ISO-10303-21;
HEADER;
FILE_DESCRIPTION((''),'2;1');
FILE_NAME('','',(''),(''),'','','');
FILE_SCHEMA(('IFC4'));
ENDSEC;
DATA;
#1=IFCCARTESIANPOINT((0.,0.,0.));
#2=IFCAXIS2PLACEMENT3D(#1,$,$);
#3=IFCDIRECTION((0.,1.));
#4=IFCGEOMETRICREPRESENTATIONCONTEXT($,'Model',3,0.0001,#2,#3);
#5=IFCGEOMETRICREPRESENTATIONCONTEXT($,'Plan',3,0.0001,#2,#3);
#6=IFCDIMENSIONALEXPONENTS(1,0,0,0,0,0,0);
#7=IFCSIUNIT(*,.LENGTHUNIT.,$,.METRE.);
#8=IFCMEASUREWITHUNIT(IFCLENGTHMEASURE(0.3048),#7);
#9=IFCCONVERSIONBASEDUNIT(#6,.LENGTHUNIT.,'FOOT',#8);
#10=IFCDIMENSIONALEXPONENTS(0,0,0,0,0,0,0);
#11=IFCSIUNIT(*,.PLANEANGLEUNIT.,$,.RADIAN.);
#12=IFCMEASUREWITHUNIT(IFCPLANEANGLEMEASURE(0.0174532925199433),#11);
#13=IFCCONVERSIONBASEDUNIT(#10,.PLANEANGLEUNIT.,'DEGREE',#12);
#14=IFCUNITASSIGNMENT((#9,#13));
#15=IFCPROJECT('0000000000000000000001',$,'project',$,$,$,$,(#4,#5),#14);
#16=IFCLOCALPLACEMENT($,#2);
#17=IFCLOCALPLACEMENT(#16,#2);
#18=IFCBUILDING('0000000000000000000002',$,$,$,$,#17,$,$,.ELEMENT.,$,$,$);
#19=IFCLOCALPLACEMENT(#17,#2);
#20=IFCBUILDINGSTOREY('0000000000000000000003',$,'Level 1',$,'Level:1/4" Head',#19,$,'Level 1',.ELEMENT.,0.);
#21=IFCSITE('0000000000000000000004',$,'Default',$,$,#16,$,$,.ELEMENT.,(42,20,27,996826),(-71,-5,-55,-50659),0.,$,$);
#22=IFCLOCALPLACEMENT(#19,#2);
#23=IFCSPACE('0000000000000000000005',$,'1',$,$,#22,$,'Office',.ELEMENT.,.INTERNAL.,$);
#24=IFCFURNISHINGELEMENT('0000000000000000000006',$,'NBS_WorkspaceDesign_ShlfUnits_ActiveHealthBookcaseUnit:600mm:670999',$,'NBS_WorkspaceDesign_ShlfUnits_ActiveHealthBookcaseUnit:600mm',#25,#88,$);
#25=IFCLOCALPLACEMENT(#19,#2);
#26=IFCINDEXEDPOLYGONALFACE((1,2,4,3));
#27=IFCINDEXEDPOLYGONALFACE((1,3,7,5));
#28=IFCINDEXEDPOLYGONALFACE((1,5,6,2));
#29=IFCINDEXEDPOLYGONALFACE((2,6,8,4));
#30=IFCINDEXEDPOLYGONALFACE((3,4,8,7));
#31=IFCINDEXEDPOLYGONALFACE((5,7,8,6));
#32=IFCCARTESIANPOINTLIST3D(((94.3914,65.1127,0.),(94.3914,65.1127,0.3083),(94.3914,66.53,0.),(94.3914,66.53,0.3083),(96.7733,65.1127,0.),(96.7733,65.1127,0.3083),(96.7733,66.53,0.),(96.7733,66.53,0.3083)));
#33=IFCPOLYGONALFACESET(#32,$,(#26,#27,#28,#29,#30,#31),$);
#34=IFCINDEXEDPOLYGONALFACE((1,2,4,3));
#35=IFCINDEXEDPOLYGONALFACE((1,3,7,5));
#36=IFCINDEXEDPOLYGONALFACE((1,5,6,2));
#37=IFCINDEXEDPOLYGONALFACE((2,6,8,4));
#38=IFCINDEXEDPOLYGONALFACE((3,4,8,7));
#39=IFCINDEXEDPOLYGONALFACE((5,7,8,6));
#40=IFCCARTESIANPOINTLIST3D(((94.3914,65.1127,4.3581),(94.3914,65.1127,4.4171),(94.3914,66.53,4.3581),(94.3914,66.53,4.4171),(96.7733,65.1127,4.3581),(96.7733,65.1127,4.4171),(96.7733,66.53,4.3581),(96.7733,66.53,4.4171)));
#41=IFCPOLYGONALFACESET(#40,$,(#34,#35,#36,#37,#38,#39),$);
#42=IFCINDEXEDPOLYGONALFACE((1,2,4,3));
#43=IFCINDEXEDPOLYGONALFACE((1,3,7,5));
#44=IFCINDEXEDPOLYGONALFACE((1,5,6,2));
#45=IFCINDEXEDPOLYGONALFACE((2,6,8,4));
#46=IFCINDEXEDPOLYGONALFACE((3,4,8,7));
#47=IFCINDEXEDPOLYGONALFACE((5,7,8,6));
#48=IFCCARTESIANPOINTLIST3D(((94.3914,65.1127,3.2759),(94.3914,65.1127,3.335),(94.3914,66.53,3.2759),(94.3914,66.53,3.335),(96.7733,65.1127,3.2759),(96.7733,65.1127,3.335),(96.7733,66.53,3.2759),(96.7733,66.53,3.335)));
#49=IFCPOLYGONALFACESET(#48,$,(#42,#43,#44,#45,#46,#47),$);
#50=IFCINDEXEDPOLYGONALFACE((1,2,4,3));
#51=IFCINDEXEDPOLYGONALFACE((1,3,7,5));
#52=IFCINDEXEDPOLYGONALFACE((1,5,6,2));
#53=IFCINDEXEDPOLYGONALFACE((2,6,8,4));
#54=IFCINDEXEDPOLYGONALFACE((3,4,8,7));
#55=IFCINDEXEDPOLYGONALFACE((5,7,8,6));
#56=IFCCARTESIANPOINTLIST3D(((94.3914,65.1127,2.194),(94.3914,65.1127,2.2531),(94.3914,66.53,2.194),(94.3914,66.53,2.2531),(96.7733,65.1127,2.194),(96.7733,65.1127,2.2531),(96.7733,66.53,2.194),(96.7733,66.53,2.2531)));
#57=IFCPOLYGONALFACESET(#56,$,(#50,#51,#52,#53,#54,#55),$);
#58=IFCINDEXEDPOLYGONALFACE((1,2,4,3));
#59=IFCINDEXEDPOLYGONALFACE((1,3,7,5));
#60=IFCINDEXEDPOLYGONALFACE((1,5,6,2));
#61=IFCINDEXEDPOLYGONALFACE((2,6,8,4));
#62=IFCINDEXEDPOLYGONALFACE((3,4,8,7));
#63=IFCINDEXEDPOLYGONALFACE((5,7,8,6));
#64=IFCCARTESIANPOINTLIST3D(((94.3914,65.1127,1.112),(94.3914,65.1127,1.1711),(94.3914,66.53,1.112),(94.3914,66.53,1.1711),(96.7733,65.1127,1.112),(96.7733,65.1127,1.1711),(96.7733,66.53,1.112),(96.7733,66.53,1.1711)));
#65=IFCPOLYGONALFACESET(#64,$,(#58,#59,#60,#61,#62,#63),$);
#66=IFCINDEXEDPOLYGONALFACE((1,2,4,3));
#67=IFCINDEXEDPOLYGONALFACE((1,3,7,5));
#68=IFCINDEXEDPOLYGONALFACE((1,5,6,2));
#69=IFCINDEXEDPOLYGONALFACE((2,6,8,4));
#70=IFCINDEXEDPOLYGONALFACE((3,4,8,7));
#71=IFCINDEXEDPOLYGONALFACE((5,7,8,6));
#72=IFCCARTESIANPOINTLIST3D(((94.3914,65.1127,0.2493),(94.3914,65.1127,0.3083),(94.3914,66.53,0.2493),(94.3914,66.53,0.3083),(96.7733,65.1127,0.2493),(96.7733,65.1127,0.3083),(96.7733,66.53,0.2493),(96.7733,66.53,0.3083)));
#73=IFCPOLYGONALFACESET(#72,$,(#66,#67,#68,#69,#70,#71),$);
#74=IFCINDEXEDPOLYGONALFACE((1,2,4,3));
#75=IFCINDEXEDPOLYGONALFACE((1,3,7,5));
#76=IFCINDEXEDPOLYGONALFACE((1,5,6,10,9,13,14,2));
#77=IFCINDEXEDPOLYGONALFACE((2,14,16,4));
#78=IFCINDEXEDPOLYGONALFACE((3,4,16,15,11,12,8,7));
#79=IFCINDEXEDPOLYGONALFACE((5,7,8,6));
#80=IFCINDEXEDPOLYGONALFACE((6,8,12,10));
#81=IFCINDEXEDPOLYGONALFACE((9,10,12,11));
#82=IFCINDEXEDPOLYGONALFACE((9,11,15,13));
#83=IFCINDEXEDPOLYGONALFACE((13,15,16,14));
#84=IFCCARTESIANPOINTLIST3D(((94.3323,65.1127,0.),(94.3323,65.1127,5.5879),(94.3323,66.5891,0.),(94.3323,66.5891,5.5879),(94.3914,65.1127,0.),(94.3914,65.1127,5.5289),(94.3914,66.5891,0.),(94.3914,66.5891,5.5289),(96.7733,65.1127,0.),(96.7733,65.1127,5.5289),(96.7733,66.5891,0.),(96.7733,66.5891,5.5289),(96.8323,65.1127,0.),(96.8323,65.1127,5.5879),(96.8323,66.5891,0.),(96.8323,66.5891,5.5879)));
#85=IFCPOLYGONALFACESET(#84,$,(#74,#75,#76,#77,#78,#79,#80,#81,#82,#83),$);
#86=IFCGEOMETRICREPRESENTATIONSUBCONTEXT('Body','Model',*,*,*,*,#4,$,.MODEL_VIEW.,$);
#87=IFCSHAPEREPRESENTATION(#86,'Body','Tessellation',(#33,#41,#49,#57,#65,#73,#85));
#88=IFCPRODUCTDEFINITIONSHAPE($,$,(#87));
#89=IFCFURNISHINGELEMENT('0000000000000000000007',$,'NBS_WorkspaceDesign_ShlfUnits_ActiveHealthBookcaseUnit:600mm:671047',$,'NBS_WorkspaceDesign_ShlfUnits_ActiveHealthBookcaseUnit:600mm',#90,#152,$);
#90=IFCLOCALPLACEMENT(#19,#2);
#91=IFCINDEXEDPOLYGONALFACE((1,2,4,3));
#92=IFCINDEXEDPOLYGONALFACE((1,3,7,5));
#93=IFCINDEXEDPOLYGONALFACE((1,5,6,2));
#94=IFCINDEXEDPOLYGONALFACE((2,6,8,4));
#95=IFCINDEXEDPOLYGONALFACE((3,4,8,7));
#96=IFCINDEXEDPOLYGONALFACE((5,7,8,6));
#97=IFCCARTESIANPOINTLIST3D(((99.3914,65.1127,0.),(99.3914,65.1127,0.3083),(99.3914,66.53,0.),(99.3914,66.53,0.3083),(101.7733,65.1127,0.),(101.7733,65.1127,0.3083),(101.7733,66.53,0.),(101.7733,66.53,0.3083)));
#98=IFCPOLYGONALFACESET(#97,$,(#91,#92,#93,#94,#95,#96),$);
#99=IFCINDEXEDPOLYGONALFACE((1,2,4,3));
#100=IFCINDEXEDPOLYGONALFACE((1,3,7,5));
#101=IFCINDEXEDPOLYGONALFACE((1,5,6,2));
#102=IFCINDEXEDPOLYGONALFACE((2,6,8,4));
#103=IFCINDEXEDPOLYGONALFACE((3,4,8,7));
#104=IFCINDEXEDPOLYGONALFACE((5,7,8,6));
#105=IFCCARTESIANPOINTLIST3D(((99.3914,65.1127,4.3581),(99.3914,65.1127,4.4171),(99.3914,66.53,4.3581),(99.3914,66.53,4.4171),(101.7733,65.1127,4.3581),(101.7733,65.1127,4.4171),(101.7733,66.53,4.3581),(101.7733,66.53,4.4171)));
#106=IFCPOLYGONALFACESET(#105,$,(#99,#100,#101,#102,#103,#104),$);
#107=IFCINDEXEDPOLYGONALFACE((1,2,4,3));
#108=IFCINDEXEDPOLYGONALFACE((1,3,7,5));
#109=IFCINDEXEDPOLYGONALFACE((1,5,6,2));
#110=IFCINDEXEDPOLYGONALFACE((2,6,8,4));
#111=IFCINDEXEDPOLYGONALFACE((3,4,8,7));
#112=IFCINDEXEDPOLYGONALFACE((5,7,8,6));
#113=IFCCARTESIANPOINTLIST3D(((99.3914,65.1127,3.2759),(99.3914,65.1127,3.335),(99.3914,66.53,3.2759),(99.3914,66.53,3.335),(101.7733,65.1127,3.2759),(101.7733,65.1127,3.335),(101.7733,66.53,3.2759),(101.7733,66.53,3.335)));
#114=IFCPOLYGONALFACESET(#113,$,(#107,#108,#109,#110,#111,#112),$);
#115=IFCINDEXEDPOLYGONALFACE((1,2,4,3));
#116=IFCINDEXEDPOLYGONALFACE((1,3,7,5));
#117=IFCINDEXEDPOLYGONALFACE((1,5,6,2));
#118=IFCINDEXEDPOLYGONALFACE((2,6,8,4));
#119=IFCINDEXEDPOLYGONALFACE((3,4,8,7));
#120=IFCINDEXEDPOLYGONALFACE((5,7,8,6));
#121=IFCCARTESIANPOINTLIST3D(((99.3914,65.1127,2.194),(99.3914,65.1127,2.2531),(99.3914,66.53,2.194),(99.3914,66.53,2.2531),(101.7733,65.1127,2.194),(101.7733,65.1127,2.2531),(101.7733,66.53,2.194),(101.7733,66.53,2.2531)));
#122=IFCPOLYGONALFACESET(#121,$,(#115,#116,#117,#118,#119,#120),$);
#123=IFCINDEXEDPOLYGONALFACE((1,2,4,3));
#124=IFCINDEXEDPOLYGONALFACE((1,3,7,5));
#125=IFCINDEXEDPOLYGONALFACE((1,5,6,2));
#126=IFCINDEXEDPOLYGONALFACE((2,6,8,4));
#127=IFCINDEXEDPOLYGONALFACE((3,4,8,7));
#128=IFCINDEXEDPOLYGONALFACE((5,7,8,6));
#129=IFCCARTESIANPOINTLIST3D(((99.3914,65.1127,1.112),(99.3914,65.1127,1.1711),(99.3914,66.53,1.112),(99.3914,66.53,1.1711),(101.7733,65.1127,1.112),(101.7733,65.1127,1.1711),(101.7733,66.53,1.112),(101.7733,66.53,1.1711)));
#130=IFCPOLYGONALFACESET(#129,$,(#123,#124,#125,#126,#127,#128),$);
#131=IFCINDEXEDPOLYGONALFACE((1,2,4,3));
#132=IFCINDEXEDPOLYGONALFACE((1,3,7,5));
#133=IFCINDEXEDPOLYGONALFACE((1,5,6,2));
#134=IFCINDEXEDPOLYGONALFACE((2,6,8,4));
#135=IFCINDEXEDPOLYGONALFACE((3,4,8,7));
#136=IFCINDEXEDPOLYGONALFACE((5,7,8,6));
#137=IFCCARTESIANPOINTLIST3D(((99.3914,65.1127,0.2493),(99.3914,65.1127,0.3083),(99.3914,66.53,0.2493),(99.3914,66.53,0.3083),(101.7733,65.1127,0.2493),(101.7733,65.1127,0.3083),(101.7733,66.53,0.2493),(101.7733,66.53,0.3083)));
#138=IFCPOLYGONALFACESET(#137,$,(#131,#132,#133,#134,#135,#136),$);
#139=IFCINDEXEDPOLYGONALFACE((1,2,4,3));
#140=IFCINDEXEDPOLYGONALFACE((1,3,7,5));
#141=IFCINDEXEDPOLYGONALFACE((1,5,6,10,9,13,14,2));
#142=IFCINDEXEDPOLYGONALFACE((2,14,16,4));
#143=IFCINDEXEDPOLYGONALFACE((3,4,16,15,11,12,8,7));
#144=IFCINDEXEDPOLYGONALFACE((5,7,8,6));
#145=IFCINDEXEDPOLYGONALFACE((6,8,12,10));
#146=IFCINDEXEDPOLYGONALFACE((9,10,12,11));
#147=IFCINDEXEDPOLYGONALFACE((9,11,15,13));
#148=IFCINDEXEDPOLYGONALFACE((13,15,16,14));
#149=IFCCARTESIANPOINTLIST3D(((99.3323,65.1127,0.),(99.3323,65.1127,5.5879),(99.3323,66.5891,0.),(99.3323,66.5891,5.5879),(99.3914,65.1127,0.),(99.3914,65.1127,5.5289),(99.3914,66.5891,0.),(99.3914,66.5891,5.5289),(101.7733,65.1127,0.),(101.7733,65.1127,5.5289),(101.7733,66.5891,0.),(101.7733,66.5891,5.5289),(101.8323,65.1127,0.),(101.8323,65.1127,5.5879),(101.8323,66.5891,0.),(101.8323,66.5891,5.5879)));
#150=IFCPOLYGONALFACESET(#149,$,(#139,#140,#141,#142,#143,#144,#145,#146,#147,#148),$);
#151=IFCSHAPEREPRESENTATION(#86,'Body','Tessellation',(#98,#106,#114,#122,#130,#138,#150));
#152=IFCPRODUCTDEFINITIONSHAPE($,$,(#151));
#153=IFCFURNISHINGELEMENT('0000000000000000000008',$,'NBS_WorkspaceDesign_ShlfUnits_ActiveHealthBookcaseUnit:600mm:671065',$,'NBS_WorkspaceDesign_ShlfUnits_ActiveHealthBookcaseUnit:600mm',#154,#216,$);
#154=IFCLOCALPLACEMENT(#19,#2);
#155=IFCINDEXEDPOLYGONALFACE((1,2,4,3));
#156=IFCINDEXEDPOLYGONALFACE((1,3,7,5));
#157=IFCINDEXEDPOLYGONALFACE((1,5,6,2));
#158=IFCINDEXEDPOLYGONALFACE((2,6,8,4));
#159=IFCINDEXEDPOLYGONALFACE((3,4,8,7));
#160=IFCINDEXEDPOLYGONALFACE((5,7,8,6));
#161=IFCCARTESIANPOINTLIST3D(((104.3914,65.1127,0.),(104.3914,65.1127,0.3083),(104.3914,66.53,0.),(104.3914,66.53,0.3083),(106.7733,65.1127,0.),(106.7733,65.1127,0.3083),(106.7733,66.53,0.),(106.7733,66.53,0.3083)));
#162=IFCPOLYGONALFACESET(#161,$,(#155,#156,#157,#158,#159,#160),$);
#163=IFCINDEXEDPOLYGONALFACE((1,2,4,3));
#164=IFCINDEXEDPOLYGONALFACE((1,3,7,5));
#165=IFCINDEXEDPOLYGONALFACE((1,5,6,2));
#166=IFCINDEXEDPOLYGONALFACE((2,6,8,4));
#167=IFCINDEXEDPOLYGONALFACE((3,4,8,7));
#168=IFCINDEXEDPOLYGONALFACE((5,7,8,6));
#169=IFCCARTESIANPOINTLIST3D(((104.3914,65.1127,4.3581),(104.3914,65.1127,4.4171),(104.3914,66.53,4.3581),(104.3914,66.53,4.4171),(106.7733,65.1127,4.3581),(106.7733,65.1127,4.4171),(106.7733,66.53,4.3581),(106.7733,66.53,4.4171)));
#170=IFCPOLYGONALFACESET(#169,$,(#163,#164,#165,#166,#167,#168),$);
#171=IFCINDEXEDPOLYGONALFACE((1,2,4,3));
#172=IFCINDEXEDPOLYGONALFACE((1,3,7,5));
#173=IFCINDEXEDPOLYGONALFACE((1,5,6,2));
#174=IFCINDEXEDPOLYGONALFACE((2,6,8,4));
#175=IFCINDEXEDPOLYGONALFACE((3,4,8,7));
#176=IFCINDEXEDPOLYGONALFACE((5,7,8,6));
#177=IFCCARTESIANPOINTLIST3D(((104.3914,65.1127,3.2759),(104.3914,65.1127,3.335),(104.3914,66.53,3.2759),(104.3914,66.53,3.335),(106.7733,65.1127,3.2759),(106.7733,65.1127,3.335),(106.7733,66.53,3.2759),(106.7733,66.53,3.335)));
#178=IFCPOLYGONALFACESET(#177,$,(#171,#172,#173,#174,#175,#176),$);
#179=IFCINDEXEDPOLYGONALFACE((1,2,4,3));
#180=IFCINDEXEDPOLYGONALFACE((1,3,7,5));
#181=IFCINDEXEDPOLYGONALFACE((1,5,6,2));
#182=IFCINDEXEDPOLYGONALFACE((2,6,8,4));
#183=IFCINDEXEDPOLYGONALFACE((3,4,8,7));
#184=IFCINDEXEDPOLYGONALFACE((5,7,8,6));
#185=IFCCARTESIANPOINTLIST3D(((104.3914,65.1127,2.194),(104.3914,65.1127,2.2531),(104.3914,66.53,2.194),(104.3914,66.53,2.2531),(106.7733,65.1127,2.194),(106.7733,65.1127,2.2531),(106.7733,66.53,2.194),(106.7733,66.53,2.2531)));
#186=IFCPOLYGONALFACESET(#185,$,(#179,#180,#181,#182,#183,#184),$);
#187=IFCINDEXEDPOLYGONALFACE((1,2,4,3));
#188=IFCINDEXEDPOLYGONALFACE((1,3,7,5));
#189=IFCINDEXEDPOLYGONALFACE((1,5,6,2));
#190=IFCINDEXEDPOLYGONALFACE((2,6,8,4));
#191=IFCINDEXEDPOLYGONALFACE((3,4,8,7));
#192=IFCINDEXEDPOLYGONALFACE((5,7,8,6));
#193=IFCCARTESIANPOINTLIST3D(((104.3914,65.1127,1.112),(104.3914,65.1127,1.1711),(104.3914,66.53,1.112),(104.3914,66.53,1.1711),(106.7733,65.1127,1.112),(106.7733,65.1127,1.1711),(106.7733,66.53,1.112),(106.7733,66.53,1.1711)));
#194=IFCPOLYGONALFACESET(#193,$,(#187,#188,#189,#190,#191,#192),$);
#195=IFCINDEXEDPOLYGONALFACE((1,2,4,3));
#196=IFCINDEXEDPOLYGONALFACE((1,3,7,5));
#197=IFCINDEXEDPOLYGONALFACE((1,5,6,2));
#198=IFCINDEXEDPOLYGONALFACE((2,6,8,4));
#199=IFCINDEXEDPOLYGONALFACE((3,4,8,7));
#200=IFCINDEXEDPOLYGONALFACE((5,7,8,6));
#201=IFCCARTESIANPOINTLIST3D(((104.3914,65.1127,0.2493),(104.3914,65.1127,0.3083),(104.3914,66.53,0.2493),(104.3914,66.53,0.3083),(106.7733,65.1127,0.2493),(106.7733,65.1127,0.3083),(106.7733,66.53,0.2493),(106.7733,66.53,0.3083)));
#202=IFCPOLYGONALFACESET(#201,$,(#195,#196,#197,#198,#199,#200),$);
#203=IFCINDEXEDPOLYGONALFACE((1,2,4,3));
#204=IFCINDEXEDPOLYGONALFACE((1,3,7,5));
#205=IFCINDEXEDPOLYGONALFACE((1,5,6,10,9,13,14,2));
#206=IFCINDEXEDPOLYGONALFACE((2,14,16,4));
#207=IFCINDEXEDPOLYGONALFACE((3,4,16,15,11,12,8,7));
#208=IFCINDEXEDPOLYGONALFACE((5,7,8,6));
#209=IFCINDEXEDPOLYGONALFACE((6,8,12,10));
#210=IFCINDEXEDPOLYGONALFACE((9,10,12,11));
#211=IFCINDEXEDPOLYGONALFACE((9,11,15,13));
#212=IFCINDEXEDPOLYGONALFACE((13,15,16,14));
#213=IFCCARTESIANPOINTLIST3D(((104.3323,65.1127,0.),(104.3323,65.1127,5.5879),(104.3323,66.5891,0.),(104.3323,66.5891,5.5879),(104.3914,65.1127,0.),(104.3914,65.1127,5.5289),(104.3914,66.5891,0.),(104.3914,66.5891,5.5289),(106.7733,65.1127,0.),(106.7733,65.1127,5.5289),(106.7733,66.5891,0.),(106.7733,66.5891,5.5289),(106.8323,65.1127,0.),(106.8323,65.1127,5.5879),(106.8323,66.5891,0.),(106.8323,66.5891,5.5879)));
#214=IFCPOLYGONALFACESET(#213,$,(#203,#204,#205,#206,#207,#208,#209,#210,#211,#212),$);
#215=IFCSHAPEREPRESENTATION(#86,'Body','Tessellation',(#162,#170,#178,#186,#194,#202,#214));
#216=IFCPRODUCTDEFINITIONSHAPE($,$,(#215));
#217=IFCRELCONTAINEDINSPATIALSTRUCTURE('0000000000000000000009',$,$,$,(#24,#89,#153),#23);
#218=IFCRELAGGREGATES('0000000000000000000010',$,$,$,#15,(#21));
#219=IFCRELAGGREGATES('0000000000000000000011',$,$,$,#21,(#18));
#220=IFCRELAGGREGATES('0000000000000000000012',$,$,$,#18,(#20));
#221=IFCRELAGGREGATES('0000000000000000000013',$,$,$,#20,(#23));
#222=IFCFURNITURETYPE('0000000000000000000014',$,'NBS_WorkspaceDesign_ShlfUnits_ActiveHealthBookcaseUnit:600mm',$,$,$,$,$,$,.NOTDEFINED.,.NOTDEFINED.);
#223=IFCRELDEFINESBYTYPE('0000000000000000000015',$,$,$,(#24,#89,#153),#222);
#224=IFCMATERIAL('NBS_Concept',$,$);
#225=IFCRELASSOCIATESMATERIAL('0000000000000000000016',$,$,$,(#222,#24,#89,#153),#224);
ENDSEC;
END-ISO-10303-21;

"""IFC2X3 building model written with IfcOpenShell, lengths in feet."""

from ifc_helpers import new_model, entity, si_unit, converted_unit, direction, frame, frame_2d, origin, place, context, subcontext, project, spatial, polyline, rectangle, outline, extrude, source, transform, mapped, material, type_object, type_shapes, element, save


model = new_model("IFC2X3")

# Units and contexts
model_context = context("Model", 3, precision=0.0001, world=origin(), true_north=direction((0.0, 1.0)))
plan_context = context("Plan", 3, precision=0.0001, world=origin(), true_north=direction((0.0, 1.0)))
body_context = subcontext(model_context, "Body", "Model", "MODEL_VIEW")
ifc_project = project(units=[converted_unit("LENGTHUNIT", "FOOT", entity("IfcLengthMeasure", 0.3048), si_unit("LENGTHUNIT", "METRE"), dimensions=[1, 0, 0, 0, 0, 0, 0]), converted_unit("PLANEANGLEUNIT", "DEGREE", entity("IfcPlaneAngleMeasure", 0.0174532925199433), si_unit("PLANEANGLEUNIT", "RADIAN"), dimensions=[0, 0, 0, 0, 0, 0, 0])], contexts=[model_context, plan_context])

# Site, building, storey
site_placement = place(None, origin())
site = spatial("IfcSite", under=ifc_project, at=site_placement, Name="Default", CompositionType="ELEMENT", RefLatitude=(42, 20, 27, 996826), RefLongitude=(-71, -5, -55, -50659), RefElevation=0.0)
building_placement = place(site_placement, origin())
building = spatial("IfcBuilding", under=site, at=building_placement, CompositionType="ELEMENT")
storey_placement = place(building_placement, origin())
storey = spatial("IfcBuildingStorey", under=building, at=storey_placement, Name="Level 1", ObjectType="Level:1/4\" Head", LongName="Level 1", CompositionType="ELEMENT", Elevation=0.0)

# Shared definitions
space_placement = place(storey_placement, origin())
space = spatial("IfcSpace", under=storey, at=space_placement, Name="1", LongName="Office", CompositionType="ELEMENT", InteriorOrExteriorSpace="INTERNAL")

# Furnishing elements
ifc_material_1 = material(Name="NBS_Concept")
furniture_type_1 = type_object("IfcFurnitureType", Name="NBS_WorkspaceDesign_ShlfUnits_ActiveHealthBookcaseUnit:600mm", AssemblyPlace="NOTDEFINED", material=ifc_material_1)
shared_shape_1 = source(origin(), body_context, "Body", "SweptSolid", [
    extrude(rectangle(XDim=1.4173, YDim=2.3819, at=frame_2d((0.0, 0.0), x_axis=(1.0, 0.0))), frame((0.0, -0.7677, 0.0), z_axis=(0.0, 0.0, 1.0), x_axis=(0.0, 1.0, 0.0)), (0.0, 0.0, 1.0), 0.3083),
    extrude(rectangle(XDim=1.4173, YDim=2.3819, at=frame_2d((0.0, 0.0), x_axis=(1.0, 0.0))), frame((0.0, -0.7677, 4.3581), z_axis=(0.0, 0.0, 1.0), x_axis=(0.0, 1.0, 0.0)), (0.0, 0.0, 1.0), 0.0591),
    extrude(rectangle(XDim=1.4173, YDim=2.3819, at=frame_2d((0.0, 0.0), x_axis=(1.0, 0.0))), frame((0.0, -0.7677, 3.2759), z_axis=(0.0, 0.0, 1.0), x_axis=(0.0, 1.0, 0.0)), (0.0, 0.0, 1.0), 0.0591),
    extrude(rectangle(XDim=1.4173, YDim=2.3819, at=frame_2d((0.0, 0.0), x_axis=(1.0, 0.0))), frame((0.0, -0.7677, 2.194), z_axis=(0.0, 0.0, 1.0), x_axis=(0.0, 1.0, 0.0)), (0.0, 0.0, 1.0), 0.0591),
    extrude(rectangle(XDim=1.4173, YDim=2.3819, at=frame_2d((0.0, 0.0), x_axis=(1.0, 0.0))), frame((0.0, -0.7677, 1.112), z_axis=(0.0, 0.0, 1.0), x_axis=(0.0, 1.0, 0.0)), (0.0, 0.0, 1.0), 0.0591),
    extrude(rectangle(XDim=1.4173, YDim=2.3819, at=frame_2d((0.0, 0.0), x_axis=(1.0, 0.0))), frame((0.0, -0.7677, 0.2493), z_axis=(0.0, 0.0, 1.0), x_axis=(0.0, 1.0, 0.0)), (0.0, 0.0, 1.0), 0.0591),
    extrude(outline(polyline([(-2.8087, -1.25), (2.7792, -1.25), (2.7792, -1.1909), (-2.7497, -1.1909), (-2.7497, 1.1909), (2.7792, 1.1909), (2.7792, 1.25), (-2.8087, 1.25), (-2.8087, -1.25)])), frame((0.0, -1.4764, 2.7792), z_axis=(0.0, 1.0, 0.0), x_axis=(0.0, 0.0, -1.0)), (0.0, 0.0, 1.0), 1.4764),
])
type_shapes(furniture_type_1, [shared_shape_1])
for number, where, name in (
    (1, (95.5823, 66.5891, 0.0), "NBS_WorkspaceDesign_ShlfUnits_ActiveHealthBookcaseUnit:600mm:670999"),
    (2, (100.5823, 66.5891, 0.0), "NBS_WorkspaceDesign_ShlfUnits_ActiveHealthBookcaseUnit:600mm:671047"),
    (3, (105.5823, 66.5891, 0.0), "NBS_WorkspaceDesign_ShlfUnits_ActiveHealthBookcaseUnit:600mm:671065"),
):
    element("IfcFurnishingElement", number, at=place(space_placement, frame(where)), inside=space, type_object=furniture_type_1, material=ifc_material_1, Name=name, ObjectType="NBS_WorkspaceDesign_ShlfUnits_ActiveHealthBookcaseUnit:600mm", context=body_context, shape_type="MappedRepresentation", body=[
        mapped(shared_shape_1, transform((0.0, 0.0, 0.0), scale=1.0)),
    ])

save(model, "model.ifc")
